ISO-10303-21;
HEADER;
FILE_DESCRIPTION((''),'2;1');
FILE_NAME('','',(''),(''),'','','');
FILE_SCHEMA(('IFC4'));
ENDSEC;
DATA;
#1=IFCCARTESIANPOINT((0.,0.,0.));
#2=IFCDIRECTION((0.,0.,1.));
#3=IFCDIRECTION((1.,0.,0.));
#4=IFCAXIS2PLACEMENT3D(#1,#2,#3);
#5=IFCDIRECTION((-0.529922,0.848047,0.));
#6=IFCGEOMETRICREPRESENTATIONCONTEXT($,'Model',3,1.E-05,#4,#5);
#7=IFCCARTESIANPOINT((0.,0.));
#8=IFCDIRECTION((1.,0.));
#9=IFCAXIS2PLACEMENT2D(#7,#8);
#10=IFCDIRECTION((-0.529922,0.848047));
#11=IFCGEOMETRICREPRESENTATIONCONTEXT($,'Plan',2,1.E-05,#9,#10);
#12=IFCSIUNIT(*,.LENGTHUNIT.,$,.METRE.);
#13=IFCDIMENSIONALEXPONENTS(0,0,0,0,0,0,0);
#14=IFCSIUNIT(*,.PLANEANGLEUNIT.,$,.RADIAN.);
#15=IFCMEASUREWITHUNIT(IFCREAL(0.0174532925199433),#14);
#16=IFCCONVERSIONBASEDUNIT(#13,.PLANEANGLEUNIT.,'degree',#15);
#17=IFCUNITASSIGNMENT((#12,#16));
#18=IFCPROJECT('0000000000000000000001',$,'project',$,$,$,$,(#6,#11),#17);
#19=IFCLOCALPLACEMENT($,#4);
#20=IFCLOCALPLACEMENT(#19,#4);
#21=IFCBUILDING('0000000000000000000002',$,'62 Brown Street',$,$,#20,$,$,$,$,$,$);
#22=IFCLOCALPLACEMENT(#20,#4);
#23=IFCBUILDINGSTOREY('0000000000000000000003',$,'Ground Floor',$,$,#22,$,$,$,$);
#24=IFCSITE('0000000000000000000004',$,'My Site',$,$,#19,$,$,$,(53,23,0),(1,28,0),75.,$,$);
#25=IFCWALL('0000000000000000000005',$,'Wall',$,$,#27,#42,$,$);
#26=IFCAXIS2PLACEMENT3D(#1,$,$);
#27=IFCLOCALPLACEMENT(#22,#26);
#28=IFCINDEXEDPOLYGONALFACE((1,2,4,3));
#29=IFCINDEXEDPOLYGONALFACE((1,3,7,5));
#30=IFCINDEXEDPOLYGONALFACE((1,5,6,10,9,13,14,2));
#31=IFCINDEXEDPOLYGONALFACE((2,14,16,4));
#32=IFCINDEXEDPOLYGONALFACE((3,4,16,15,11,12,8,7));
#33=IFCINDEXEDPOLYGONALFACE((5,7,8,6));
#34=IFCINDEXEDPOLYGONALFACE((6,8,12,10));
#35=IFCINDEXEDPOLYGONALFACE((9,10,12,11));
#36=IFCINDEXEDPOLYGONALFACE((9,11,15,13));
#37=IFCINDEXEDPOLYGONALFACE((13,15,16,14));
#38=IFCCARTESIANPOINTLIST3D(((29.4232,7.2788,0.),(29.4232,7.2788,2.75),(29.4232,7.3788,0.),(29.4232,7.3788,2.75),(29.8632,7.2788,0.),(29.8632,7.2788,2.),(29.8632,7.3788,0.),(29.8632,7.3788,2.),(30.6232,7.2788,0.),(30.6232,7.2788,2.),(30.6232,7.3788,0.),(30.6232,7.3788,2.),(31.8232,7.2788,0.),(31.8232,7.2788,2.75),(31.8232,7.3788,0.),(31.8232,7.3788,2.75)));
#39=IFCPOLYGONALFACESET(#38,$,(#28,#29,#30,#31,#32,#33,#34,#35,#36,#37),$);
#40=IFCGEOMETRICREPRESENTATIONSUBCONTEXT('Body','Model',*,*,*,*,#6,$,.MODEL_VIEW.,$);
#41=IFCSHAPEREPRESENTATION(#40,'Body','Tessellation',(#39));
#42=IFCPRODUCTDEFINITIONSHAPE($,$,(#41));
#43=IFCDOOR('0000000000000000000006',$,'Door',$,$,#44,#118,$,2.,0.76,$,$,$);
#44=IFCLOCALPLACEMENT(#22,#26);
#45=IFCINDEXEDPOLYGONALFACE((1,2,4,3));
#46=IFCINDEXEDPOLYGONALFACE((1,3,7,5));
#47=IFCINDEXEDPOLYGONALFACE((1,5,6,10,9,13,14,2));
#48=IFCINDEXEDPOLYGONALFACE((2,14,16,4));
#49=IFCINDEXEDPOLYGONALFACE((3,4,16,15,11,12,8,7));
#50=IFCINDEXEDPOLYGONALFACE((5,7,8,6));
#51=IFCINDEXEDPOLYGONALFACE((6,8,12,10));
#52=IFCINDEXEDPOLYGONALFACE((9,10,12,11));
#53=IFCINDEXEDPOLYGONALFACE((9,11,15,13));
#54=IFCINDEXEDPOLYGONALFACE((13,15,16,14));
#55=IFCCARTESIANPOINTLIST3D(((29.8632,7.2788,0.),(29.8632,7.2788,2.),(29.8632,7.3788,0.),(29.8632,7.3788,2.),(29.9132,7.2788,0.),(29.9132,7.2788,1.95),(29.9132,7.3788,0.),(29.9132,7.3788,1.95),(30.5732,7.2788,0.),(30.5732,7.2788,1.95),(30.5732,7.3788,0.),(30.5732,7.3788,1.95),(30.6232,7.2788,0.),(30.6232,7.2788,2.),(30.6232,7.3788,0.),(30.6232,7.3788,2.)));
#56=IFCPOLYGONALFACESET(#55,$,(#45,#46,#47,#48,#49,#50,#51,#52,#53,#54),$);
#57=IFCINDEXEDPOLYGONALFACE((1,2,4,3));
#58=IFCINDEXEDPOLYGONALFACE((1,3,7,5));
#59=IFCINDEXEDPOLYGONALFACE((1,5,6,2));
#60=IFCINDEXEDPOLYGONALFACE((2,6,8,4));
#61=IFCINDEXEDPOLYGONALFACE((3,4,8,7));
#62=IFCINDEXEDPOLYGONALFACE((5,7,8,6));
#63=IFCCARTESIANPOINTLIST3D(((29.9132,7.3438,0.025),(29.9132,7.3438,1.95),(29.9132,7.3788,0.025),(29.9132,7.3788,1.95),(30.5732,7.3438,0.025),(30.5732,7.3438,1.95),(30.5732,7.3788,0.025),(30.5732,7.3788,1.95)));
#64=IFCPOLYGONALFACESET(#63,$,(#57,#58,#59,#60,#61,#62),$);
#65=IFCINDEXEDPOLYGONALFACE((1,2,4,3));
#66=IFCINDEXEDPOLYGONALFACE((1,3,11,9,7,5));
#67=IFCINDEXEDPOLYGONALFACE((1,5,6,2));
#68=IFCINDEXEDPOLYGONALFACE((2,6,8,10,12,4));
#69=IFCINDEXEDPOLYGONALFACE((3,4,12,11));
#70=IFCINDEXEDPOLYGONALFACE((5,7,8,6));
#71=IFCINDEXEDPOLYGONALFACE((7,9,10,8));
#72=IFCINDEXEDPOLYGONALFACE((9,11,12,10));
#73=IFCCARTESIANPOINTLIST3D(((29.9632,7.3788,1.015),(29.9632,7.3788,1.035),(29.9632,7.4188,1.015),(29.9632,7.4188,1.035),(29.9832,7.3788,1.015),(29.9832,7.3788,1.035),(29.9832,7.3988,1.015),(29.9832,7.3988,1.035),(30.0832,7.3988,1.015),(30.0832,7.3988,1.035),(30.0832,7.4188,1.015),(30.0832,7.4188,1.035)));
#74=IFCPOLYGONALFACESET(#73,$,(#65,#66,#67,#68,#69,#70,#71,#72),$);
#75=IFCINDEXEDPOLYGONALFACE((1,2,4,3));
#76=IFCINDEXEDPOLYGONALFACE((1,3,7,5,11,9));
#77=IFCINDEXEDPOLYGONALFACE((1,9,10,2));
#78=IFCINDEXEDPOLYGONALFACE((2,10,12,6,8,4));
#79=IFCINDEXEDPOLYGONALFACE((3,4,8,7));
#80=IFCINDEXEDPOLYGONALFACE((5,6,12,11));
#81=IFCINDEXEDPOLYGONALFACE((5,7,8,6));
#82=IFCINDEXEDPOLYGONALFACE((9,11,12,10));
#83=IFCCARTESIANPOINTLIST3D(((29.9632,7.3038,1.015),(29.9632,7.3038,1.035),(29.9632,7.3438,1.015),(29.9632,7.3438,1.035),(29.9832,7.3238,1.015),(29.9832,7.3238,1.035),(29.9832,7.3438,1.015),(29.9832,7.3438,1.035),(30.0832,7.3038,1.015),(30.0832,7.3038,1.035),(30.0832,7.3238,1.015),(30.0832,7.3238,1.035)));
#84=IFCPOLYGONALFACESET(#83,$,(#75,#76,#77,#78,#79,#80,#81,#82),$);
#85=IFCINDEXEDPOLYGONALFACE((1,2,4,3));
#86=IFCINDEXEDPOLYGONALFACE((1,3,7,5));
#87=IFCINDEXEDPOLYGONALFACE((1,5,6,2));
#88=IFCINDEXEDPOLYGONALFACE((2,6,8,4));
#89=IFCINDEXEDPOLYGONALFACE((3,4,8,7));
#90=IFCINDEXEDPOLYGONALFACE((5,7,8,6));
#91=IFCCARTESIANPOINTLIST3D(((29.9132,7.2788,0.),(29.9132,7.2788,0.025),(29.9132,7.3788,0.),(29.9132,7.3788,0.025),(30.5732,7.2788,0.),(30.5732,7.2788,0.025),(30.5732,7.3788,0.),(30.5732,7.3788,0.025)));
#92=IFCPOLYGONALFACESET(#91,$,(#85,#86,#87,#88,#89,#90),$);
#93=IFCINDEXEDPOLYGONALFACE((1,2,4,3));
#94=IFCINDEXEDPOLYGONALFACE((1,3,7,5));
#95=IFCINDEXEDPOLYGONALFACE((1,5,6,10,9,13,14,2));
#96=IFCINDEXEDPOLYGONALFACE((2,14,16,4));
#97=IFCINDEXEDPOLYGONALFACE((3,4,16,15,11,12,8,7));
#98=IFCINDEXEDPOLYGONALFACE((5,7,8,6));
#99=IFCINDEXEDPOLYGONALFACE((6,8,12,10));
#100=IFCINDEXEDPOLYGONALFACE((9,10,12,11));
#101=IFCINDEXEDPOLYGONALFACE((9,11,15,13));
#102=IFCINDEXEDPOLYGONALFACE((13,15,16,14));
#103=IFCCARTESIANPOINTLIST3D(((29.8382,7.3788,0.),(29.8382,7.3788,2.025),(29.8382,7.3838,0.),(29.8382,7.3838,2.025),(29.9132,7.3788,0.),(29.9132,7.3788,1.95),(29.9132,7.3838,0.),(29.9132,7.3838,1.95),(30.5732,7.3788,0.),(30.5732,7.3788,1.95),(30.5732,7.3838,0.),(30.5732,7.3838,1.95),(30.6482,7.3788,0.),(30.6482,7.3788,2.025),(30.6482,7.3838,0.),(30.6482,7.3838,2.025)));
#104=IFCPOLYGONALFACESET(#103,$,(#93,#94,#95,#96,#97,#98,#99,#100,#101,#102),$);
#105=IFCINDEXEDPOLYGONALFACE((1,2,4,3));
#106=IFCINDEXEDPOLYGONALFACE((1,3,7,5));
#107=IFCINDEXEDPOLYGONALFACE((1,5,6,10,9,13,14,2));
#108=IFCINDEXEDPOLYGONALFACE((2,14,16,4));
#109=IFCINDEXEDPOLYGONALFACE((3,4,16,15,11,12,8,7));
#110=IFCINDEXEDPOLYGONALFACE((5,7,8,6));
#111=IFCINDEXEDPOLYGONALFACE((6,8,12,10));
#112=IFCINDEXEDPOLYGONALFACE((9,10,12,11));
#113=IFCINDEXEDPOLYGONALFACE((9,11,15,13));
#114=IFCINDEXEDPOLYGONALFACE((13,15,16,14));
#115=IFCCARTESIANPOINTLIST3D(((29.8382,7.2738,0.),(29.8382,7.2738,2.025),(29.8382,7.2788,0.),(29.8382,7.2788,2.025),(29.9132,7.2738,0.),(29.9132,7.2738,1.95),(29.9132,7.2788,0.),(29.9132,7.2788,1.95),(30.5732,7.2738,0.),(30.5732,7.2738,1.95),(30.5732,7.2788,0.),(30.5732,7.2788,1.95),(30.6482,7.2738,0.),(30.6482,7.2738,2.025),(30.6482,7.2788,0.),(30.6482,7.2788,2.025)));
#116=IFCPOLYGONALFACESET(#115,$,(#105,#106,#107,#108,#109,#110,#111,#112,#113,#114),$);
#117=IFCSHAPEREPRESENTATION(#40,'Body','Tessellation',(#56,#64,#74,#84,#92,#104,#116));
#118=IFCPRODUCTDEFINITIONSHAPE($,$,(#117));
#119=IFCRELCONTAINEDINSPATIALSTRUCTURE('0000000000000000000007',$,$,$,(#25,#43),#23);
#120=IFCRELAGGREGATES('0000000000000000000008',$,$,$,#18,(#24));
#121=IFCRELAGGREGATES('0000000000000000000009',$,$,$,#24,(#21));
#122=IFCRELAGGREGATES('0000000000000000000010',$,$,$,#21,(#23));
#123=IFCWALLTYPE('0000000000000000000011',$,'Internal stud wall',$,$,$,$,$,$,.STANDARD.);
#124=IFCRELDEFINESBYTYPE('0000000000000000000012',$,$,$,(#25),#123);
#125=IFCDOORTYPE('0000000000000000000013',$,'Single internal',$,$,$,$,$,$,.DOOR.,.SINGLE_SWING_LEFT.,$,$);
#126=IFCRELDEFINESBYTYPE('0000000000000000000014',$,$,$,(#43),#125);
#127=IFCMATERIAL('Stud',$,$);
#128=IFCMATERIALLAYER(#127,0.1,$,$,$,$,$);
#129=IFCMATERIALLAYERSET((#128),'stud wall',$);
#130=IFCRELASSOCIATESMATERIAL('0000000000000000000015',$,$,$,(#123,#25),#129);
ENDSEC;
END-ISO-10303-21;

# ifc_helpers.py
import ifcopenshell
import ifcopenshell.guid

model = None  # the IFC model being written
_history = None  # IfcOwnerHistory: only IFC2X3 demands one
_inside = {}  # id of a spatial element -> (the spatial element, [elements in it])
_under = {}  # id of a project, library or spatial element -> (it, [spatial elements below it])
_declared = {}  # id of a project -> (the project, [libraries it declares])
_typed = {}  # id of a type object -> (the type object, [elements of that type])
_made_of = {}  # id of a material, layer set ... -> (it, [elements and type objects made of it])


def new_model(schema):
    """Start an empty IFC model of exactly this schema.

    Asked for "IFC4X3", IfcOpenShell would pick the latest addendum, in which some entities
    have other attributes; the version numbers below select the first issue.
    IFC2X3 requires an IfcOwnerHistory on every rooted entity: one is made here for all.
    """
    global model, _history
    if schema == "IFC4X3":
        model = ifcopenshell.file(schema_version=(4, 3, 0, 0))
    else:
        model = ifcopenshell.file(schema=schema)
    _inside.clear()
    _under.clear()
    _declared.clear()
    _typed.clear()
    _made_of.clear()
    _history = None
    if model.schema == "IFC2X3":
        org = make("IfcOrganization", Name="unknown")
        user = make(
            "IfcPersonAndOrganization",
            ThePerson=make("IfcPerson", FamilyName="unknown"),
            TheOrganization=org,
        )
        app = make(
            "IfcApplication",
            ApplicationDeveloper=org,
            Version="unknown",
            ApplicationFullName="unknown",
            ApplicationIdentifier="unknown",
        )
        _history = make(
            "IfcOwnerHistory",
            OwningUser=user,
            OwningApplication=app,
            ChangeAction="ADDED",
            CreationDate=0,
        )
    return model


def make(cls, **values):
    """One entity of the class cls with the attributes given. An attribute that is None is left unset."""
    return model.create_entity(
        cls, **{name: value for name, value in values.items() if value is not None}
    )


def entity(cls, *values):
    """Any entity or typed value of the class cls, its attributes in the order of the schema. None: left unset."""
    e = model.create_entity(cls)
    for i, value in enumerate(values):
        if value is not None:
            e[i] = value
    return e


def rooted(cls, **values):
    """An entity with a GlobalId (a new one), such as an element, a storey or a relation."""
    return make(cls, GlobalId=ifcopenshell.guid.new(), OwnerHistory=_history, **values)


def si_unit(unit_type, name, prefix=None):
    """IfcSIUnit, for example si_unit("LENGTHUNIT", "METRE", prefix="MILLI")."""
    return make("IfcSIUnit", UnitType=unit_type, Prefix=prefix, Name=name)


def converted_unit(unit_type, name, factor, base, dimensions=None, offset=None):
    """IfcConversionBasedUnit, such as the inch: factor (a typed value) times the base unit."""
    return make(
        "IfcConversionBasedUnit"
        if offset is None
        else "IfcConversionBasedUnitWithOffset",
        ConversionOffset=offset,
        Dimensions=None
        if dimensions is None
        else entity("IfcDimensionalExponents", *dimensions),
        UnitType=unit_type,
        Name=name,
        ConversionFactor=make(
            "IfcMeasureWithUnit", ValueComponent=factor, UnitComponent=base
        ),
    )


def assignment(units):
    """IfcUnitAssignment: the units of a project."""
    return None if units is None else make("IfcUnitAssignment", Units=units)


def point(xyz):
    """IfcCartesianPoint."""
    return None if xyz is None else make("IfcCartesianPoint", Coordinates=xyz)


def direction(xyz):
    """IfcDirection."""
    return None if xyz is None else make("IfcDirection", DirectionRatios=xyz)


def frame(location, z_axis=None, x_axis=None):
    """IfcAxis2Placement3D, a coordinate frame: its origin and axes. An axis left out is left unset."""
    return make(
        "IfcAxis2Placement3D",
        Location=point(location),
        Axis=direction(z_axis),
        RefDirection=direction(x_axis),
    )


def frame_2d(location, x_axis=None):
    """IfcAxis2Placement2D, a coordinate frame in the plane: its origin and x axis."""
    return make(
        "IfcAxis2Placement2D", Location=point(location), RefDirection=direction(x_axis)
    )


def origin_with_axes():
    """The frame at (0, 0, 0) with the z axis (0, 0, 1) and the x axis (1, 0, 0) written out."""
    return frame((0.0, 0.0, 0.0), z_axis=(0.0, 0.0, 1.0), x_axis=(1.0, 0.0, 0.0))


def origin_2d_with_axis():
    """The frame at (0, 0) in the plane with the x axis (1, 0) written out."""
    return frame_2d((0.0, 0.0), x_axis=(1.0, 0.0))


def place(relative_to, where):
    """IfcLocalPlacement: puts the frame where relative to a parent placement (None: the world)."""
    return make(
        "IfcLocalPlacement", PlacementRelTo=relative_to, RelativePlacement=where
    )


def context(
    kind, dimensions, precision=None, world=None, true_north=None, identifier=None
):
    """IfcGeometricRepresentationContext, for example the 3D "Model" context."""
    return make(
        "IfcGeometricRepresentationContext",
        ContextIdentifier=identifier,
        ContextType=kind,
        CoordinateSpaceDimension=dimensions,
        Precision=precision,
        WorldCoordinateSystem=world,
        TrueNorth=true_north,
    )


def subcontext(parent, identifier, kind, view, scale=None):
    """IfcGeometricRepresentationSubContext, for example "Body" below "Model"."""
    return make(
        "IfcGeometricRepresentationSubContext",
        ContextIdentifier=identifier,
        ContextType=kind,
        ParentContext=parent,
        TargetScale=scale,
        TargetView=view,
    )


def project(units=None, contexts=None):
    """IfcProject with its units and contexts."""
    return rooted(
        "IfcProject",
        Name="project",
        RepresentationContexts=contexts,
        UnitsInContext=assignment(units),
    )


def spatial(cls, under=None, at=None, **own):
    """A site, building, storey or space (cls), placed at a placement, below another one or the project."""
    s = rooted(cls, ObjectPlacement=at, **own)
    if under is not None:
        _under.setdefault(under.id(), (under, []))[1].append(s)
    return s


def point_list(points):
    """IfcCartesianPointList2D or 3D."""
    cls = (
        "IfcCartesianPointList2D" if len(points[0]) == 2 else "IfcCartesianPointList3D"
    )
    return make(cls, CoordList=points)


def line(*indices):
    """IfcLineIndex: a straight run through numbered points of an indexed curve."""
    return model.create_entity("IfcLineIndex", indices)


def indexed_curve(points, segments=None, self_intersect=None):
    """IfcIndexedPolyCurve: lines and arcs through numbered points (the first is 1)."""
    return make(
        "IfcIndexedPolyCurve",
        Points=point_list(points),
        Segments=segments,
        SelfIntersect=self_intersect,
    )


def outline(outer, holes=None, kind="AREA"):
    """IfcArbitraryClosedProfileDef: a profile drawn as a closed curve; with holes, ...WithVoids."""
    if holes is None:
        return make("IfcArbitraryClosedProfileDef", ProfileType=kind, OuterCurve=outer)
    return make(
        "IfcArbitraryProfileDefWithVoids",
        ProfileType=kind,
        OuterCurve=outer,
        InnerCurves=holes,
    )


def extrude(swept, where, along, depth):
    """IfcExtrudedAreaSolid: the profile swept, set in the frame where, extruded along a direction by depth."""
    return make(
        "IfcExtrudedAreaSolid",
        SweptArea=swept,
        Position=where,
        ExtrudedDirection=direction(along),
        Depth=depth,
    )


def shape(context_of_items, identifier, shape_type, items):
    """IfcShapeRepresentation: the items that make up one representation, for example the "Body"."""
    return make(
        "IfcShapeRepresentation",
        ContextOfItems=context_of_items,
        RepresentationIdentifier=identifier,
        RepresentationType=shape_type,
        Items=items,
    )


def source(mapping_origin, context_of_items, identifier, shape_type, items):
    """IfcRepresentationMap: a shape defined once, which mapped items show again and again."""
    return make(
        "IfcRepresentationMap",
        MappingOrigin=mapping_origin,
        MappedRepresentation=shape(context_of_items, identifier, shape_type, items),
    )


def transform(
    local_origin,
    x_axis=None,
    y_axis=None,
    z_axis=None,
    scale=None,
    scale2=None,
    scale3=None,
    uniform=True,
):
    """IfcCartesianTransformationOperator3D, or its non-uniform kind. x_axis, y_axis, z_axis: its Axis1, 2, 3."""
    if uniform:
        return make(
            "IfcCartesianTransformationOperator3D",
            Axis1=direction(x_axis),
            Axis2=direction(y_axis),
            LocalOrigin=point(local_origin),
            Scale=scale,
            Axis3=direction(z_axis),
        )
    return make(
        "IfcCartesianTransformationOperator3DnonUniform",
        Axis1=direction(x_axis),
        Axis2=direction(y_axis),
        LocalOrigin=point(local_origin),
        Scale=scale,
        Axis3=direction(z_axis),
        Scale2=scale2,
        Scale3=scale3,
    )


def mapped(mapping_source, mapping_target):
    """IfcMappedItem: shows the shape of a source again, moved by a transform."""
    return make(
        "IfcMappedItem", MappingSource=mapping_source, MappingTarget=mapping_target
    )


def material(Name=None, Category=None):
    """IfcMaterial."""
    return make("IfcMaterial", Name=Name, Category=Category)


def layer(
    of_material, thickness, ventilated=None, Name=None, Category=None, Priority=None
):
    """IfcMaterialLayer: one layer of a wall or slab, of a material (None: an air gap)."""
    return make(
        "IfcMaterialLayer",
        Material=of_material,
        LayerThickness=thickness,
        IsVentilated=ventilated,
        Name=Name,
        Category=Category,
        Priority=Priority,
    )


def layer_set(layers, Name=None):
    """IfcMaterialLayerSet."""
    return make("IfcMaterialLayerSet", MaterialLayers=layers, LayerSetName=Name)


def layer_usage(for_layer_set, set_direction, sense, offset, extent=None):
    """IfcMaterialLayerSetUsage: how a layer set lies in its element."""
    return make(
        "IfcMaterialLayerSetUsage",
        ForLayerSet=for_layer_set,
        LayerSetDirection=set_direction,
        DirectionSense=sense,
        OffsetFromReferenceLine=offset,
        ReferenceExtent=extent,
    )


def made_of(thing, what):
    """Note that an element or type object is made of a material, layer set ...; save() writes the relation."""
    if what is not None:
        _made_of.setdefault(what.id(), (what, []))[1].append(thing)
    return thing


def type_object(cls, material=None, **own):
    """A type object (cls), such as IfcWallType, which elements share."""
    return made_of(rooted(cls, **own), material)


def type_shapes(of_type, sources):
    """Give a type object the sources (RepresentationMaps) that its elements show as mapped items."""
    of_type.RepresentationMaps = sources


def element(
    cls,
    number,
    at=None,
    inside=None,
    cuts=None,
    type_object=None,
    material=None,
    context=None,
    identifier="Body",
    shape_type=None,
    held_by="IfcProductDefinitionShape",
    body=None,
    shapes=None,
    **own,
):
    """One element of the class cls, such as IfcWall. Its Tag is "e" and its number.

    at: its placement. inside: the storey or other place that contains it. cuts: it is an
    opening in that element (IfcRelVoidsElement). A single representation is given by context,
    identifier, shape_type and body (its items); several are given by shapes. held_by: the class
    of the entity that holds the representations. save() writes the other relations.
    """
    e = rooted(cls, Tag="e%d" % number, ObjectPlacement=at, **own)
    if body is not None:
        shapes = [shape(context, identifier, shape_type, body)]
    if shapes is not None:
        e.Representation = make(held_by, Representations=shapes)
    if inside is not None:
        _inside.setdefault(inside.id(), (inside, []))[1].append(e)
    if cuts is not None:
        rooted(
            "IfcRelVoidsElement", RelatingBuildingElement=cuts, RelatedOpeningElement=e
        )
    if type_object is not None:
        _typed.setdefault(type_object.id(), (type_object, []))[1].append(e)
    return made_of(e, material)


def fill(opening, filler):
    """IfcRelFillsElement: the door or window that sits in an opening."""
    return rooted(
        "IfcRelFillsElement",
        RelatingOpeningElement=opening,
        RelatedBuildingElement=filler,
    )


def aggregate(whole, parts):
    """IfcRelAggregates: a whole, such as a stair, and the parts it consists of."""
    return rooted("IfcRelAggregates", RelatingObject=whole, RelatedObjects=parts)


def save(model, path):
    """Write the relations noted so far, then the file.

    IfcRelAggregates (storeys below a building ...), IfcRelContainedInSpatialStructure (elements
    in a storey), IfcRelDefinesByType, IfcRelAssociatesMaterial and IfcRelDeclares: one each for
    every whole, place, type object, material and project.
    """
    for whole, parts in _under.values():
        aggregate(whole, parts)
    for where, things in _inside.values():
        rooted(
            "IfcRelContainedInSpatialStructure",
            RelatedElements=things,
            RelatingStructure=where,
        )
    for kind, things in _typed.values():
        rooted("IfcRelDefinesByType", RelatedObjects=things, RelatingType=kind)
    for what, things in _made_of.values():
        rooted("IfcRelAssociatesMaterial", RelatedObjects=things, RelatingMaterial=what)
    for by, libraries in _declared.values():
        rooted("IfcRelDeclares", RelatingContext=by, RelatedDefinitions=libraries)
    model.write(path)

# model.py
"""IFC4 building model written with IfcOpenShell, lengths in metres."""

from ifc_helpers import new_model, entity, si_unit, converted_unit, direction, frame, origin_with_axes, origin_2d_with_axis, place, context, subcontext, project, spatial, line, indexed_curve, outline, extrude, shape, source, transform, mapped, material, layer, layer_set, layer_usage, type_object, type_shapes, element, fill, save


model = new_model("IFC4")

# Units and contexts
model_context = context("Model", 3, precision=1e-05, world=origin_with_axes(), true_north=direction((-0.529922, 0.848047, 0.0)))
plan_context = context("Plan", 2, precision=1e-05, world=origin_2d_with_axis(), true_north=direction((-0.529922, 0.848047)))
body_context_1 = subcontext(model_context, "Body", "Model", "MODEL_VIEW")
body_context_2 = subcontext(plan_context, "Body", "Plan", "PLAN_VIEW")
ifc_project = project(units=[si_unit("LENGTHUNIT", "METRE"), converted_unit("PLANEANGLEUNIT", "degree", entity("IfcReal", 0.0174532925199433), si_unit("PLANEANGLEUNIT", "RADIAN"), dimensions=[0, 0, 0, 0, 0, 0, 0])], contexts=[model_context, plan_context])

# Site, building, storey
site_placement = place(None, origin_with_axes())
site = spatial("IfcSite", under=ifc_project, at=site_placement, Name="My Site", RefLatitude=(53, 23, 0), RefLongitude=(1, 28, 0), RefElevation=75.0)
building_placement = place(site_placement, origin_with_axes())
building = spatial("IfcBuilding", under=site, at=building_placement, Name="62 Brown Street")
storey_placement = place(building_placement, origin_with_axes())
storey = spatial("IfcBuildingStorey", under=building, at=storey_placement, Name="Ground Floor")

# Wall, opening, door
ifc_material_1 = material(Name="Stud")
ifc_layer_1 = layer(ifc_material_1, 0.1)
ifc_layer_set_1 = layer_set([ifc_layer_1], Name="stud wall")
ifc_layer_usage_1 = layer_usage(ifc_layer_set_1, "AXIS2", "POSITIVE", 0.0)
wall_type_1 = type_object("IfcWallType", Name="Internal stud wall", PredefinedType="STANDARD", material=ifc_layer_set_1)
wall_1_placement = place(storey_placement, frame((31.8232, 7.3788, 0.0), z_axis=(0.0, 0.0, 1.0), x_axis=(-1.0, 0.0, 0.0)))
wall_1 = element("IfcWall", 1, at=wall_1_placement, inside=storey, type_object=wall_type_1, material=ifc_layer_usage_1, Name="Wall", context=body_context_1, shape_type="SweptSolid", body=[
    extrude(outline(indexed_curve([(0.0, 0.0), (0.0, 0.1), (2.4, 0.1), (2.4, 0.0), (0.0, 0.0)], self_intersect=False)), origin_with_axes(), (0.0, 0.0, 1.0), 2.75),
])
shared_shape_1 = source(origin_with_axes(), body_context_1, "Body", "SweptSolid", [
    extrude(outline(indexed_curve([(0.0, 0.0), (0.76, 0.0), (0.76, 2.0), (0.0, 2.0)], segments=[line(1, 2, 3, 4, 1)])), frame((0.0, -0.6, 0.0), z_axis=(0.0, -1.0, 0.0), x_axis=(1.0, 0.0, 0.0)), (0.0, 0.0, -1.0), 1.2),
])
opening_1_placement = place(wall_1_placement, frame((1.2, 0.0, 0.0), z_axis=(0.0, 0.0, 1.0), x_axis=(1.0, 0.0, 0.0)))
opening_1 = element("IfcOpeningElement", 2, at=opening_1_placement, cuts=wall_1, PredefinedType="OPENING", context=body_context_1, shape_type="MappedRepresentation", body=[
    mapped(shared_shape_1, transform((0.0, 0.0, 0.0), x_axis=(1.0, 0.0, 0.0), y_axis=(0.0, 1.0, 0.0), z_axis=(0.0, 0.0, 1.0), scale=1.0)),
])
door_type_1 = type_object("IfcDoorType", Name="Single internal", OperationType="SINGLE_SWING_LEFT", PredefinedType="DOOR")
shared_shape_2 = source(origin_with_axes(), body_context_1, "Body", "SweptSolid", [
    extrude(outline(indexed_curve([(0.0, 0.0), (0.0, 2.0), (0.76, 2.0), (0.76, 0.0), (0.71, 0.0), (0.71, 1.95), (0.05, 1.95), (0.05, 0.0)], segments=[line(1, 2, 3, 4, 5, 6, 7, 8, 1)])), frame((0.0, 0.0, 0.0), z_axis=(0.0, -1.0, 0.0), x_axis=(1.0, 0.0, 0.0)), (0.0, 0.0, -1.0), 0.1),
    extrude(outline(indexed_curve([(0.0, 0.0), (0.66, 0.0), (0.66, 0.035), (0.0, 0.035)], segments=[line(1, 2, 3, 4, 1)])), frame((0.05, 0.0, 0.025), z_axis=(0.0, 0.0, 1.0), x_axis=(1.0, 0.0, 0.0)), (0.0, 0.0, 1.0), 1.925),
    extrude(outline(indexed_curve([(0.0, 0.0), (0.0, -0.04), (-0.12, -0.04), (-0.12, -0.02), (-0.02, -0.02), (-0.02, 0.0)], segments=[line(1, 2, 3, 4, 5, 6, 1)])), frame((0.66, 0.0, 1.015), z_axis=(0.0, 0.0, 1.0), x_axis=(1.0, 0.0, 0.0)), (0.0, 0.0, 1.0), 0.02),
    extrude(outline(indexed_curve([(0.0, 0.0), (0.0, 0.04), (-0.12, 0.04), (-0.12, 0.02), (-0.02, 0.02), (-0.02, 0.0)], segments=[line(1, 2, 3, 4, 5, 6, 1)])), frame((0.66, 0.035, 1.015), z_axis=(0.0, 0.0, 1.0), x_axis=(1.0, 0.0, 0.0)), (0.0, 0.0, 1.0), 0.02),
    extrude(outline(indexed_curve([(0.0, 0.0), (0.66, 0.0), (0.66, 0.1), (0.0, 0.1)], segments=[line(1, 2, 3, 4, 1)])), frame((0.05, 0.0, 0.0), z_axis=(0.0, 0.0, 1.0), x_axis=(1.0, 0.0, 0.0)), (0.0, 0.0, 1.0), 0.025),
    extrude(outline(indexed_curve([(0.0, 0.0), (0.0, 2.025), (0.81, 2.025), (0.81, 0.0), (0.735, 0.0), (0.735, 1.95), (0.075, 1.95), (0.075, 0.0)], segments=[line(1, 2, 3, 4, 5, 6, 7, 8, 1)])), frame((-0.025, -0.005, 0.0), z_axis=(0.0, -1.0, 0.0), x_axis=(1.0, 0.0, 0.0)), (0.0, 0.0, -1.0), 0.005),
    extrude(outline(indexed_curve([(0.0, 0.0), (0.0, 2.025), (0.81, 2.025), (0.81, 0.0), (0.735, 0.0), (0.735, 1.95), (0.075, 1.95), (0.075, 0.0)], segments=[line(1, 2, 3, 4, 5, 6, 7, 8, 1)])), frame((-0.025, 0.1, 0.0), z_axis=(0.0, -1.0, 0.0), x_axis=(1.0, 0.0, 0.0)), (0.0, 0.0, -1.0), 0.005),
])
shared_shape_3 = source(origin_with_axes(), body_context_2, "Body", "Curve2D", [
    entity("IfcIndexedPolyCurve", entity("IfcCartesianPointList2D", [[0.0, 0.0], [0.05, 0.0], [0.05, 0.1], [0.0, 0.1]]), [entity("IfcLineIndex", [1, 2, 3, 4, 1])]),
    entity("IfcIndexedPolyCurve", entity("IfcCartesianPointList2D", [[0.76, 0.0], [0.71, 0.0], [0.71, 0.1], [0.76, 0.1]]), [entity("IfcLineIndex", [1, 2, 3, 4, 1])]),
    entity("IfcTrimmedCurve", entity("IfcEllipse", entity("IfcAxis2Placement2D", entity("IfcCartesianPoint", [0.085, 0.1]), entity("IfcDirection", [1.0, 0.0])), 0.625, 0.66), [entity("IfcCartesianPoint", [0.71, 0.1])], [entity("IfcCartesianPoint", [0.085, 0.76])], True, "CARTESIAN"),
    entity("IfcIndexedPolyCurve", entity("IfcCartesianPointList2D", [[0.05, 0.1], [0.085, 0.1], [0.085, 0.76], [0.05, 0.76]]), [entity("IfcLineIndex", [1, 2, 3, 4, 1])]),
])
type_shapes(door_type_1, [shared_shape_2, shared_shape_3])
door_1_placement = place(opening_1_placement, frame((0.0, 0.0, 0.0), z_axis=(0.0, 0.0, 1.0), x_axis=(1.0, 0.0, 0.0)))
door_1 = element("IfcDoor", 3, at=door_1_placement, inside=storey, type_object=door_type_1, Name="Door", OverallHeight=2.0, OverallWidth=0.76, shapes=[
    shape(body_context_1, "Body", "MappedRepresentation", [mapped(shared_shape_2, transform((0.0, 0.0, 0.0), x_axis=(1.0, 0.0, 0.0), y_axis=(0.0, 1.0, 0.0), z_axis=(0.0, 0.0, 1.0), scale=1.0))]),
    shape(body_context_2, "Body", "MappedRepresentation", [mapped(shared_shape_3, transform((0.0, 0.0, 0.0), x_axis=(1.0, 0.0, 0.0), y_axis=(0.0, 1.0, 0.0), z_axis=(0.0, 0.0, 1.0), scale=1.0))]),
])
fill(opening_1, door_1)

save(model, "model.ifc")
